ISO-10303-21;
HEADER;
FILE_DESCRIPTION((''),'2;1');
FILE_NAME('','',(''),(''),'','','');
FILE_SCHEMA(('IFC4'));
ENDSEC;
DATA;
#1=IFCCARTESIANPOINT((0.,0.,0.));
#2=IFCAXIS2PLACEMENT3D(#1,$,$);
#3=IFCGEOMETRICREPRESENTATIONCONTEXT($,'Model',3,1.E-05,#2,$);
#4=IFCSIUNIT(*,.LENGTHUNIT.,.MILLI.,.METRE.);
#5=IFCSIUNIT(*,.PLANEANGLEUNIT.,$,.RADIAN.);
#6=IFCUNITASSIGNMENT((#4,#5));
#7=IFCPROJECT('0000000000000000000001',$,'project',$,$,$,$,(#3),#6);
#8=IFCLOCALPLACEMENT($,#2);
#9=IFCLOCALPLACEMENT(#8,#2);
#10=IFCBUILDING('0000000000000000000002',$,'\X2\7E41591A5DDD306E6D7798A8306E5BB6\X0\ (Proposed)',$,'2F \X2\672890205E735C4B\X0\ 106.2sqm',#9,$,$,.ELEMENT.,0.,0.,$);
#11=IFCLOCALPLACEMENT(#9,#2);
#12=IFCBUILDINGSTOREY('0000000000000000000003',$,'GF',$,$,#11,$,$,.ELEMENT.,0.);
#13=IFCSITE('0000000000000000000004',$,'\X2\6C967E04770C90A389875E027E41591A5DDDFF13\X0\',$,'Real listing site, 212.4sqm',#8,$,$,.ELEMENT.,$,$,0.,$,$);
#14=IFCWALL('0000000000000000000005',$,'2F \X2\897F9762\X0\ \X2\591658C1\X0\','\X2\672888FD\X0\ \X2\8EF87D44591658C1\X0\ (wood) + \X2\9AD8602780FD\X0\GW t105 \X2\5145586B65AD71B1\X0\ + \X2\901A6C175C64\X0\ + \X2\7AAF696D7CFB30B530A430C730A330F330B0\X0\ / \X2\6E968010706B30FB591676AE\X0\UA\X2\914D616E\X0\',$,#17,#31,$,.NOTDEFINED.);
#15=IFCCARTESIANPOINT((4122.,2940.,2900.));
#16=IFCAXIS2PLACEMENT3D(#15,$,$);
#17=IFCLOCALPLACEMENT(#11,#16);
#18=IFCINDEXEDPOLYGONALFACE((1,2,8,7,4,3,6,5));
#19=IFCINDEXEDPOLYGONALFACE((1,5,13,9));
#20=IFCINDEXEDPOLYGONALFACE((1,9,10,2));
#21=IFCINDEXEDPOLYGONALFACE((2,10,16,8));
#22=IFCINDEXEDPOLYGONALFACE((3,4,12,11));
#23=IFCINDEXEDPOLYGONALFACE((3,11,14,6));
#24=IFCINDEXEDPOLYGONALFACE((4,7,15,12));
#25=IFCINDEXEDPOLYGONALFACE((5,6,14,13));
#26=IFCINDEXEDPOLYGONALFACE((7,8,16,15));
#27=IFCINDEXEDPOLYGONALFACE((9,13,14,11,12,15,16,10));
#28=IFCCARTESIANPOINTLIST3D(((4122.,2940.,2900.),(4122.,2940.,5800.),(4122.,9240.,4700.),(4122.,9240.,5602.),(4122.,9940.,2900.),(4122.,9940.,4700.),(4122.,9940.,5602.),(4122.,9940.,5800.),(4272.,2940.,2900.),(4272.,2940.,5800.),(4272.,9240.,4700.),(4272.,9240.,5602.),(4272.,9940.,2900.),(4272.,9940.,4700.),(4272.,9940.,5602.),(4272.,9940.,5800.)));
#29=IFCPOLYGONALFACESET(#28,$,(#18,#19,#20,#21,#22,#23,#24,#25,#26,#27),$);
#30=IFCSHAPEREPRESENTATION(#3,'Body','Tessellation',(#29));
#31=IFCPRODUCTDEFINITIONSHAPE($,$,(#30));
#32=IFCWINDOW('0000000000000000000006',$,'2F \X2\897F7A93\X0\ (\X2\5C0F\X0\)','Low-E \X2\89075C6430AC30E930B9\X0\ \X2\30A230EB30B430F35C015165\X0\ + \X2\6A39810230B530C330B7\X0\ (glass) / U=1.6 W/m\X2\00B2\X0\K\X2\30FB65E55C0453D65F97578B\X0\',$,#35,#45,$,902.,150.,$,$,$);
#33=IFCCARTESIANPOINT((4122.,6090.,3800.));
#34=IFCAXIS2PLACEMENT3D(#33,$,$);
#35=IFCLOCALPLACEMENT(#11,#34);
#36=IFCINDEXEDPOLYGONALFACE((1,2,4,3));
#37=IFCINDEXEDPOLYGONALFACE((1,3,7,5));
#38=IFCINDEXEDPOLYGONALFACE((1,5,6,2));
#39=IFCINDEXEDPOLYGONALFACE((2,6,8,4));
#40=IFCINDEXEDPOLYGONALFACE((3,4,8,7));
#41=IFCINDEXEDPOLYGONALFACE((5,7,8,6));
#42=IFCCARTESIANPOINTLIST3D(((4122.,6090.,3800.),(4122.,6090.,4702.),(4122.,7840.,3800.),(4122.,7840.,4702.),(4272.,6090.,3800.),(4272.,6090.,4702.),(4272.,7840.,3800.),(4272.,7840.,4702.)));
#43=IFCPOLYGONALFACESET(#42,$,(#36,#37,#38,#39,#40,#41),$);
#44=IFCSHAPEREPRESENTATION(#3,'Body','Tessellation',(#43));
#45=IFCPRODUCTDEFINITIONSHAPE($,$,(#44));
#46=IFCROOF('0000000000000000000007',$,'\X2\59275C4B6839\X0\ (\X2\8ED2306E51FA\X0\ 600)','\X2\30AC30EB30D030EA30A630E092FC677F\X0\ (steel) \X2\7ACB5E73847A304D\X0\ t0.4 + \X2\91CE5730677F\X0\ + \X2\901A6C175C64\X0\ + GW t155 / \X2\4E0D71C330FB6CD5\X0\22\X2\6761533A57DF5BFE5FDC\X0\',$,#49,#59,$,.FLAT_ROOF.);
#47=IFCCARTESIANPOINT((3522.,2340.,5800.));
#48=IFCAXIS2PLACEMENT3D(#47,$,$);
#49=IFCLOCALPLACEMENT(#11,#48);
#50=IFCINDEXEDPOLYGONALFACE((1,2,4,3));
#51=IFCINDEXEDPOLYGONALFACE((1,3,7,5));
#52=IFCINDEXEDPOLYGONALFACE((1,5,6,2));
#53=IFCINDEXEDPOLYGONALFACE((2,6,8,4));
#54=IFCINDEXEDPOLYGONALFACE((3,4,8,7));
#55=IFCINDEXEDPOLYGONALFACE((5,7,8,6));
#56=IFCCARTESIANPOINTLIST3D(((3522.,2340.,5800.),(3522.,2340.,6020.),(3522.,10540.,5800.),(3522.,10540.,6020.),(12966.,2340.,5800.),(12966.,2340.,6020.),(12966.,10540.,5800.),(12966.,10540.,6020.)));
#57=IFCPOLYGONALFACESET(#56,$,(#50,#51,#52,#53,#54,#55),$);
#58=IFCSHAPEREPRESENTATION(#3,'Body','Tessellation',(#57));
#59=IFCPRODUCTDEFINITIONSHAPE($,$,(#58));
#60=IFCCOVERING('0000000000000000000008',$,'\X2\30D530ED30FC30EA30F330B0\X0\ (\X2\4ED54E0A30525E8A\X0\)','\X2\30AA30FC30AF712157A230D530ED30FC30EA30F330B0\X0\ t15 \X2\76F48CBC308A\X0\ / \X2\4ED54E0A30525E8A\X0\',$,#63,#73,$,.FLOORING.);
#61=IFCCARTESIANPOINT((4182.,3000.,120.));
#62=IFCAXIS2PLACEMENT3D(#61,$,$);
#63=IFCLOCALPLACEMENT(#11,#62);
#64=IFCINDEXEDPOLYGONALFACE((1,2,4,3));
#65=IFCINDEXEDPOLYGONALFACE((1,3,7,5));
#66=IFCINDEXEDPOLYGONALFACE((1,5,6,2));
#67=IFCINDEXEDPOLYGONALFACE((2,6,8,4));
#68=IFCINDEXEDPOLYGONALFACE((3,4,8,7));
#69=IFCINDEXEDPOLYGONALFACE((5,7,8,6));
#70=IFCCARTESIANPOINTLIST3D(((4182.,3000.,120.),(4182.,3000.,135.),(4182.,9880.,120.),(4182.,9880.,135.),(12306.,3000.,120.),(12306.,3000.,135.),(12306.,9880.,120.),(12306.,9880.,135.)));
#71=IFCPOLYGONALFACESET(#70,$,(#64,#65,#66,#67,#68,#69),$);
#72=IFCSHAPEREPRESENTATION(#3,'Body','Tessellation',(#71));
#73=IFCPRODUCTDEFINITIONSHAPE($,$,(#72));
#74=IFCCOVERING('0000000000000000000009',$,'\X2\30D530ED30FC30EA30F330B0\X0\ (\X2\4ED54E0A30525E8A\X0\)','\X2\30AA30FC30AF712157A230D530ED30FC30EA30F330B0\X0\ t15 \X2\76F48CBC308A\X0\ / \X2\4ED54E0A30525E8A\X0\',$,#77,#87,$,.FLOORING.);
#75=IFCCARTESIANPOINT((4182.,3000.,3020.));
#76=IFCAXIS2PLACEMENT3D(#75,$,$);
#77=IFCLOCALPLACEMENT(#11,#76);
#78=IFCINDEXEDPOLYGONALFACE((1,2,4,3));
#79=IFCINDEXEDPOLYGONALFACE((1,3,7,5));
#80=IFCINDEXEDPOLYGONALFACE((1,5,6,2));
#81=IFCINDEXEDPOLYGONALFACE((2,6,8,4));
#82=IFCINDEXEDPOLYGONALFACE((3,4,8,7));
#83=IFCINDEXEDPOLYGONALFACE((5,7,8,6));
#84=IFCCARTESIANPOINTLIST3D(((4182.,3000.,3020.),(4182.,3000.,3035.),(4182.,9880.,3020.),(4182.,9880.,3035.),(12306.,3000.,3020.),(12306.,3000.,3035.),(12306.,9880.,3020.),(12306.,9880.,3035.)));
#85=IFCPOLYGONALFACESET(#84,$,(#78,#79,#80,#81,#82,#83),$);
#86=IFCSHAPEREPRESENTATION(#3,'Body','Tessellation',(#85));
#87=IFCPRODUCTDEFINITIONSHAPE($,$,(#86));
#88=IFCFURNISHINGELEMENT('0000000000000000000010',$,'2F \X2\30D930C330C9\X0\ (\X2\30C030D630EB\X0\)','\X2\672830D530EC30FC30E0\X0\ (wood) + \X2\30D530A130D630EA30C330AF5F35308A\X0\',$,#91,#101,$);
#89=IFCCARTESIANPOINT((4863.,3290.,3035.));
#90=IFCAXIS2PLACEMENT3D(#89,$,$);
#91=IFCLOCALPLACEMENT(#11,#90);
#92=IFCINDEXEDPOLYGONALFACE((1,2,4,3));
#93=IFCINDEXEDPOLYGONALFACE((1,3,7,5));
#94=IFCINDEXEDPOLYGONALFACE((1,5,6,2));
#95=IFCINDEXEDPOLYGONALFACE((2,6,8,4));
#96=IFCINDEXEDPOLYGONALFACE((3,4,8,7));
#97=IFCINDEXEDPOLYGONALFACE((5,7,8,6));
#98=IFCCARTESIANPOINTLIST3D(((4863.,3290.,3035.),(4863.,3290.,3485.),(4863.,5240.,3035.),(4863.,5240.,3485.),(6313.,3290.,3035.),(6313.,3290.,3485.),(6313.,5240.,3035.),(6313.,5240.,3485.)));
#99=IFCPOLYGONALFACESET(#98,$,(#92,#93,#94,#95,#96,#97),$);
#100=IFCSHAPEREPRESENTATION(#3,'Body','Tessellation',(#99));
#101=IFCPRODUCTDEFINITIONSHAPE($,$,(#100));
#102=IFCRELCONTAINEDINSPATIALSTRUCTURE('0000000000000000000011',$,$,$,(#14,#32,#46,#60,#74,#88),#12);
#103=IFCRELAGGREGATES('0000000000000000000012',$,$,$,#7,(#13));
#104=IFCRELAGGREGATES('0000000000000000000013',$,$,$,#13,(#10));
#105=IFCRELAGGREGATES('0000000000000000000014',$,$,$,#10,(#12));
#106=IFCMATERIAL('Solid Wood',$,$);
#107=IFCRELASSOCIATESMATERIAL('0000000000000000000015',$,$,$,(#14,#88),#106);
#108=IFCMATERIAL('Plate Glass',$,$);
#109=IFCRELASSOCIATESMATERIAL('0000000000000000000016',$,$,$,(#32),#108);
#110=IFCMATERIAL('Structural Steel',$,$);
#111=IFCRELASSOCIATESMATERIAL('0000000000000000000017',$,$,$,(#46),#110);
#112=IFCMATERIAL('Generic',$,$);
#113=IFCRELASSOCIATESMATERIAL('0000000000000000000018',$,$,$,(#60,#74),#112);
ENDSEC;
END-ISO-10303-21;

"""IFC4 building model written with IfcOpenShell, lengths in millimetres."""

from ifc_helpers import new_model, si_unit, frame, frame_2d, origin, place, context, project, spatial, rectangle, extrude, material, element, fill, save


model = new_model("IFC4")

# Units and contexts
model_context = context("Model", 3, precision=1e-05, world=origin())
ifc_project = project(units=[si_unit("LENGTHUNIT", "METRE", prefix="MILLI"), si_unit("PLANEANGLEUNIT", "RADIAN")], contexts=[model_context])

# Site, building, storey
site_placement = place(None, origin())
site = spatial("IfcSite", under=ifc_project, at=site_placement, Name="沖縄県那覇市繁多川３", ObjectType="Real listing site, 212.4sqm", CompositionType="ELEMENT", RefElevation=0.0)
building_placement = place(site_placement, origin())
building = spatial("IfcBuilding", under=site, at=building_placement, Name="繁多川の海風の家 (Proposed)", ObjectType="2F 木造平屋 106.2sqm", CompositionType="ELEMENT", ElevationOfRefHeight=0.0, ElevationOfTerrain=0.0)
storey_placement = place(building_placement, origin())
storey = spatial("IfcBuildingStorey", under=building, at=storey_placement, Name="GF", CompositionType="ELEMENT", Elevation=0.0)

# Shared definitions
ifc_material_1 = material(Name="Solid Wood")

# Shared definitions
ifc_material_2 = material(Name="Plate Glass")

# Wall, opening, window
wall_1_placement = place(storey_placement, frame((4122.0, 2940.0, 2900.0)))
wall_1 = element("IfcWall", 1, at=wall_1_placement, inside=storey, material=ifc_material_1, Name="2F 西面 外壁", Description="木製 軸組外壁 (wood) + 高性能GW t105 充填断熱 + 通気層 + 窯業系サイディング / 準耐火・外皮UA配慮", PredefinedType="NOTDEFINED", context=model_context, shape_type="SweptSolid", body=[
    extrude(rectangle(XDim=150.0, YDim=7000.0, at=frame_2d((75.0, 3500.0))), frame((4122.0, 2940.0, 2900.0)), (0.0, 0.0, 1.0), 2900.0),
])
opening_1_placement = place(storey_placement, frame((4122.0, 6090.0, 3800.0)))
opening_1 = element("IfcOpeningElement", 2, at=opening_1_placement, cuts=wall_1, PredefinedType="NOTDEFINED", context=model_context, shape_type="SweptSolid", body=[
    extrude(rectangle(XDim=150.0, YDim=1750.0, at=frame_2d((75.0, 875.0))), frame((4122.0, 6090.0, 3800.0)), (0.0, 0.0, 1.0), 902.0),
])
window_1_placement = place(storey_placement, frame((4122.0, 6090.0, 3800.0)))
window_1 = element("IfcWindow", 3, at=window_1_placement, inside=storey, material=ifc_material_2, Name="2F 西窓 (小)", Description="Low-E 複層ガラス アルゴン封入 + 樹脂サッシ (glass) / U=1.6 W/m²K・日射取得型", OverallHeight=902.0, OverallWidth=150.0, context=model_context, shape_type="SweptSolid", body=[
    extrude(rectangle(XDim=150.0, YDim=1750.0, at=frame_2d((75.0, 875.0))), frame((4122.0, 6090.0, 3800.0)), (0.0, 0.0, 1.0), 902.0),
])
fill(opening_1, window_1)

# Roof
ifc_material_3 = material(Name="Structural Steel")
roof_placement = place(storey_placement, frame((3522.0, 2340.0, 5800.0)))
element("IfcRoof", 4, at=roof_placement, inside=storey, material=ifc_material_3, Name="大屋根 (軒の出 600)", Description="ガルバリウム鋼板 (steel) 立平葺き t0.4 + 野地板 + 通気層 + GW t155 / 不燃・法22条区域対応", PredefinedType="FLAT_ROOF", context=model_context, shape_type="SweptSolid", body=[
    extrude(rectangle(XDim=9444.0, YDim=8200.0, at=frame_2d((4722.0, 4100.0))), frame((3522.0, 2340.0, 5800.0)), (0.0, 0.0, 1.0), 220.0),
])

# Coverings
ifc_material_4 = material(Name="Generic")
covering_1_placement = place(storey_placement, frame((4182.0, 3000.0, 120.0)))
element("IfcCovering", 5, at=covering_1_placement, inside=storey, material=ifc_material_4, Name="フローリング (仕上げ床)", Description="オーク無垢フローリング t15 直貼り / 仕上げ床", PredefinedType="FLOORING", context=model_context, shape_type="SweptSolid", body=[
    extrude(rectangle(XDim=8124.0, YDim=6880.0, at=frame_2d((4062.0, 3440.0))), frame((4182.0, 3000.0, 120.0)), (0.0, 0.0, 1.0), 15.0),
])
covering_2_placement = place(storey_placement, frame((4182.0, 3000.0, 3020.0)))
element("IfcCovering", 6, at=covering_2_placement, inside=storey, material=ifc_material_4, Name="フローリング (仕上げ床)", Description="オーク無垢フローリング t15 直貼り / 仕上げ床", PredefinedType="FLOORING", context=model_context, shape_type="SweptSolid", body=[
    extrude(rectangle(XDim=8124.0, YDim=6880.0, at=frame_2d((4062.0, 3440.0))), frame((4182.0, 3000.0, 3020.0)), (0.0, 0.0, 1.0), 15.0),
])

# Furnishing element
furnishing_placement = place(storey_placement, frame((4863.0, 3290.0, 3035.0)))
element("IfcFurnishingElement", 7, at=furnishing_placement, inside=storey, material=ifc_material_1, Name="2F ベッド (ダブル)", Description="木フレーム (wood) + ファブリック張り", context=model_context, shape_type="SweptSolid", body=[
    extrude(rectangle(XDim=1450.0, YDim=1950.0, at=frame_2d((725.0, 975.0))), frame((4863.0, 3290.0, 3035.0)), (0.0, 0.0, 1.0), 450.0),
])

save(model, "model.ifc")
